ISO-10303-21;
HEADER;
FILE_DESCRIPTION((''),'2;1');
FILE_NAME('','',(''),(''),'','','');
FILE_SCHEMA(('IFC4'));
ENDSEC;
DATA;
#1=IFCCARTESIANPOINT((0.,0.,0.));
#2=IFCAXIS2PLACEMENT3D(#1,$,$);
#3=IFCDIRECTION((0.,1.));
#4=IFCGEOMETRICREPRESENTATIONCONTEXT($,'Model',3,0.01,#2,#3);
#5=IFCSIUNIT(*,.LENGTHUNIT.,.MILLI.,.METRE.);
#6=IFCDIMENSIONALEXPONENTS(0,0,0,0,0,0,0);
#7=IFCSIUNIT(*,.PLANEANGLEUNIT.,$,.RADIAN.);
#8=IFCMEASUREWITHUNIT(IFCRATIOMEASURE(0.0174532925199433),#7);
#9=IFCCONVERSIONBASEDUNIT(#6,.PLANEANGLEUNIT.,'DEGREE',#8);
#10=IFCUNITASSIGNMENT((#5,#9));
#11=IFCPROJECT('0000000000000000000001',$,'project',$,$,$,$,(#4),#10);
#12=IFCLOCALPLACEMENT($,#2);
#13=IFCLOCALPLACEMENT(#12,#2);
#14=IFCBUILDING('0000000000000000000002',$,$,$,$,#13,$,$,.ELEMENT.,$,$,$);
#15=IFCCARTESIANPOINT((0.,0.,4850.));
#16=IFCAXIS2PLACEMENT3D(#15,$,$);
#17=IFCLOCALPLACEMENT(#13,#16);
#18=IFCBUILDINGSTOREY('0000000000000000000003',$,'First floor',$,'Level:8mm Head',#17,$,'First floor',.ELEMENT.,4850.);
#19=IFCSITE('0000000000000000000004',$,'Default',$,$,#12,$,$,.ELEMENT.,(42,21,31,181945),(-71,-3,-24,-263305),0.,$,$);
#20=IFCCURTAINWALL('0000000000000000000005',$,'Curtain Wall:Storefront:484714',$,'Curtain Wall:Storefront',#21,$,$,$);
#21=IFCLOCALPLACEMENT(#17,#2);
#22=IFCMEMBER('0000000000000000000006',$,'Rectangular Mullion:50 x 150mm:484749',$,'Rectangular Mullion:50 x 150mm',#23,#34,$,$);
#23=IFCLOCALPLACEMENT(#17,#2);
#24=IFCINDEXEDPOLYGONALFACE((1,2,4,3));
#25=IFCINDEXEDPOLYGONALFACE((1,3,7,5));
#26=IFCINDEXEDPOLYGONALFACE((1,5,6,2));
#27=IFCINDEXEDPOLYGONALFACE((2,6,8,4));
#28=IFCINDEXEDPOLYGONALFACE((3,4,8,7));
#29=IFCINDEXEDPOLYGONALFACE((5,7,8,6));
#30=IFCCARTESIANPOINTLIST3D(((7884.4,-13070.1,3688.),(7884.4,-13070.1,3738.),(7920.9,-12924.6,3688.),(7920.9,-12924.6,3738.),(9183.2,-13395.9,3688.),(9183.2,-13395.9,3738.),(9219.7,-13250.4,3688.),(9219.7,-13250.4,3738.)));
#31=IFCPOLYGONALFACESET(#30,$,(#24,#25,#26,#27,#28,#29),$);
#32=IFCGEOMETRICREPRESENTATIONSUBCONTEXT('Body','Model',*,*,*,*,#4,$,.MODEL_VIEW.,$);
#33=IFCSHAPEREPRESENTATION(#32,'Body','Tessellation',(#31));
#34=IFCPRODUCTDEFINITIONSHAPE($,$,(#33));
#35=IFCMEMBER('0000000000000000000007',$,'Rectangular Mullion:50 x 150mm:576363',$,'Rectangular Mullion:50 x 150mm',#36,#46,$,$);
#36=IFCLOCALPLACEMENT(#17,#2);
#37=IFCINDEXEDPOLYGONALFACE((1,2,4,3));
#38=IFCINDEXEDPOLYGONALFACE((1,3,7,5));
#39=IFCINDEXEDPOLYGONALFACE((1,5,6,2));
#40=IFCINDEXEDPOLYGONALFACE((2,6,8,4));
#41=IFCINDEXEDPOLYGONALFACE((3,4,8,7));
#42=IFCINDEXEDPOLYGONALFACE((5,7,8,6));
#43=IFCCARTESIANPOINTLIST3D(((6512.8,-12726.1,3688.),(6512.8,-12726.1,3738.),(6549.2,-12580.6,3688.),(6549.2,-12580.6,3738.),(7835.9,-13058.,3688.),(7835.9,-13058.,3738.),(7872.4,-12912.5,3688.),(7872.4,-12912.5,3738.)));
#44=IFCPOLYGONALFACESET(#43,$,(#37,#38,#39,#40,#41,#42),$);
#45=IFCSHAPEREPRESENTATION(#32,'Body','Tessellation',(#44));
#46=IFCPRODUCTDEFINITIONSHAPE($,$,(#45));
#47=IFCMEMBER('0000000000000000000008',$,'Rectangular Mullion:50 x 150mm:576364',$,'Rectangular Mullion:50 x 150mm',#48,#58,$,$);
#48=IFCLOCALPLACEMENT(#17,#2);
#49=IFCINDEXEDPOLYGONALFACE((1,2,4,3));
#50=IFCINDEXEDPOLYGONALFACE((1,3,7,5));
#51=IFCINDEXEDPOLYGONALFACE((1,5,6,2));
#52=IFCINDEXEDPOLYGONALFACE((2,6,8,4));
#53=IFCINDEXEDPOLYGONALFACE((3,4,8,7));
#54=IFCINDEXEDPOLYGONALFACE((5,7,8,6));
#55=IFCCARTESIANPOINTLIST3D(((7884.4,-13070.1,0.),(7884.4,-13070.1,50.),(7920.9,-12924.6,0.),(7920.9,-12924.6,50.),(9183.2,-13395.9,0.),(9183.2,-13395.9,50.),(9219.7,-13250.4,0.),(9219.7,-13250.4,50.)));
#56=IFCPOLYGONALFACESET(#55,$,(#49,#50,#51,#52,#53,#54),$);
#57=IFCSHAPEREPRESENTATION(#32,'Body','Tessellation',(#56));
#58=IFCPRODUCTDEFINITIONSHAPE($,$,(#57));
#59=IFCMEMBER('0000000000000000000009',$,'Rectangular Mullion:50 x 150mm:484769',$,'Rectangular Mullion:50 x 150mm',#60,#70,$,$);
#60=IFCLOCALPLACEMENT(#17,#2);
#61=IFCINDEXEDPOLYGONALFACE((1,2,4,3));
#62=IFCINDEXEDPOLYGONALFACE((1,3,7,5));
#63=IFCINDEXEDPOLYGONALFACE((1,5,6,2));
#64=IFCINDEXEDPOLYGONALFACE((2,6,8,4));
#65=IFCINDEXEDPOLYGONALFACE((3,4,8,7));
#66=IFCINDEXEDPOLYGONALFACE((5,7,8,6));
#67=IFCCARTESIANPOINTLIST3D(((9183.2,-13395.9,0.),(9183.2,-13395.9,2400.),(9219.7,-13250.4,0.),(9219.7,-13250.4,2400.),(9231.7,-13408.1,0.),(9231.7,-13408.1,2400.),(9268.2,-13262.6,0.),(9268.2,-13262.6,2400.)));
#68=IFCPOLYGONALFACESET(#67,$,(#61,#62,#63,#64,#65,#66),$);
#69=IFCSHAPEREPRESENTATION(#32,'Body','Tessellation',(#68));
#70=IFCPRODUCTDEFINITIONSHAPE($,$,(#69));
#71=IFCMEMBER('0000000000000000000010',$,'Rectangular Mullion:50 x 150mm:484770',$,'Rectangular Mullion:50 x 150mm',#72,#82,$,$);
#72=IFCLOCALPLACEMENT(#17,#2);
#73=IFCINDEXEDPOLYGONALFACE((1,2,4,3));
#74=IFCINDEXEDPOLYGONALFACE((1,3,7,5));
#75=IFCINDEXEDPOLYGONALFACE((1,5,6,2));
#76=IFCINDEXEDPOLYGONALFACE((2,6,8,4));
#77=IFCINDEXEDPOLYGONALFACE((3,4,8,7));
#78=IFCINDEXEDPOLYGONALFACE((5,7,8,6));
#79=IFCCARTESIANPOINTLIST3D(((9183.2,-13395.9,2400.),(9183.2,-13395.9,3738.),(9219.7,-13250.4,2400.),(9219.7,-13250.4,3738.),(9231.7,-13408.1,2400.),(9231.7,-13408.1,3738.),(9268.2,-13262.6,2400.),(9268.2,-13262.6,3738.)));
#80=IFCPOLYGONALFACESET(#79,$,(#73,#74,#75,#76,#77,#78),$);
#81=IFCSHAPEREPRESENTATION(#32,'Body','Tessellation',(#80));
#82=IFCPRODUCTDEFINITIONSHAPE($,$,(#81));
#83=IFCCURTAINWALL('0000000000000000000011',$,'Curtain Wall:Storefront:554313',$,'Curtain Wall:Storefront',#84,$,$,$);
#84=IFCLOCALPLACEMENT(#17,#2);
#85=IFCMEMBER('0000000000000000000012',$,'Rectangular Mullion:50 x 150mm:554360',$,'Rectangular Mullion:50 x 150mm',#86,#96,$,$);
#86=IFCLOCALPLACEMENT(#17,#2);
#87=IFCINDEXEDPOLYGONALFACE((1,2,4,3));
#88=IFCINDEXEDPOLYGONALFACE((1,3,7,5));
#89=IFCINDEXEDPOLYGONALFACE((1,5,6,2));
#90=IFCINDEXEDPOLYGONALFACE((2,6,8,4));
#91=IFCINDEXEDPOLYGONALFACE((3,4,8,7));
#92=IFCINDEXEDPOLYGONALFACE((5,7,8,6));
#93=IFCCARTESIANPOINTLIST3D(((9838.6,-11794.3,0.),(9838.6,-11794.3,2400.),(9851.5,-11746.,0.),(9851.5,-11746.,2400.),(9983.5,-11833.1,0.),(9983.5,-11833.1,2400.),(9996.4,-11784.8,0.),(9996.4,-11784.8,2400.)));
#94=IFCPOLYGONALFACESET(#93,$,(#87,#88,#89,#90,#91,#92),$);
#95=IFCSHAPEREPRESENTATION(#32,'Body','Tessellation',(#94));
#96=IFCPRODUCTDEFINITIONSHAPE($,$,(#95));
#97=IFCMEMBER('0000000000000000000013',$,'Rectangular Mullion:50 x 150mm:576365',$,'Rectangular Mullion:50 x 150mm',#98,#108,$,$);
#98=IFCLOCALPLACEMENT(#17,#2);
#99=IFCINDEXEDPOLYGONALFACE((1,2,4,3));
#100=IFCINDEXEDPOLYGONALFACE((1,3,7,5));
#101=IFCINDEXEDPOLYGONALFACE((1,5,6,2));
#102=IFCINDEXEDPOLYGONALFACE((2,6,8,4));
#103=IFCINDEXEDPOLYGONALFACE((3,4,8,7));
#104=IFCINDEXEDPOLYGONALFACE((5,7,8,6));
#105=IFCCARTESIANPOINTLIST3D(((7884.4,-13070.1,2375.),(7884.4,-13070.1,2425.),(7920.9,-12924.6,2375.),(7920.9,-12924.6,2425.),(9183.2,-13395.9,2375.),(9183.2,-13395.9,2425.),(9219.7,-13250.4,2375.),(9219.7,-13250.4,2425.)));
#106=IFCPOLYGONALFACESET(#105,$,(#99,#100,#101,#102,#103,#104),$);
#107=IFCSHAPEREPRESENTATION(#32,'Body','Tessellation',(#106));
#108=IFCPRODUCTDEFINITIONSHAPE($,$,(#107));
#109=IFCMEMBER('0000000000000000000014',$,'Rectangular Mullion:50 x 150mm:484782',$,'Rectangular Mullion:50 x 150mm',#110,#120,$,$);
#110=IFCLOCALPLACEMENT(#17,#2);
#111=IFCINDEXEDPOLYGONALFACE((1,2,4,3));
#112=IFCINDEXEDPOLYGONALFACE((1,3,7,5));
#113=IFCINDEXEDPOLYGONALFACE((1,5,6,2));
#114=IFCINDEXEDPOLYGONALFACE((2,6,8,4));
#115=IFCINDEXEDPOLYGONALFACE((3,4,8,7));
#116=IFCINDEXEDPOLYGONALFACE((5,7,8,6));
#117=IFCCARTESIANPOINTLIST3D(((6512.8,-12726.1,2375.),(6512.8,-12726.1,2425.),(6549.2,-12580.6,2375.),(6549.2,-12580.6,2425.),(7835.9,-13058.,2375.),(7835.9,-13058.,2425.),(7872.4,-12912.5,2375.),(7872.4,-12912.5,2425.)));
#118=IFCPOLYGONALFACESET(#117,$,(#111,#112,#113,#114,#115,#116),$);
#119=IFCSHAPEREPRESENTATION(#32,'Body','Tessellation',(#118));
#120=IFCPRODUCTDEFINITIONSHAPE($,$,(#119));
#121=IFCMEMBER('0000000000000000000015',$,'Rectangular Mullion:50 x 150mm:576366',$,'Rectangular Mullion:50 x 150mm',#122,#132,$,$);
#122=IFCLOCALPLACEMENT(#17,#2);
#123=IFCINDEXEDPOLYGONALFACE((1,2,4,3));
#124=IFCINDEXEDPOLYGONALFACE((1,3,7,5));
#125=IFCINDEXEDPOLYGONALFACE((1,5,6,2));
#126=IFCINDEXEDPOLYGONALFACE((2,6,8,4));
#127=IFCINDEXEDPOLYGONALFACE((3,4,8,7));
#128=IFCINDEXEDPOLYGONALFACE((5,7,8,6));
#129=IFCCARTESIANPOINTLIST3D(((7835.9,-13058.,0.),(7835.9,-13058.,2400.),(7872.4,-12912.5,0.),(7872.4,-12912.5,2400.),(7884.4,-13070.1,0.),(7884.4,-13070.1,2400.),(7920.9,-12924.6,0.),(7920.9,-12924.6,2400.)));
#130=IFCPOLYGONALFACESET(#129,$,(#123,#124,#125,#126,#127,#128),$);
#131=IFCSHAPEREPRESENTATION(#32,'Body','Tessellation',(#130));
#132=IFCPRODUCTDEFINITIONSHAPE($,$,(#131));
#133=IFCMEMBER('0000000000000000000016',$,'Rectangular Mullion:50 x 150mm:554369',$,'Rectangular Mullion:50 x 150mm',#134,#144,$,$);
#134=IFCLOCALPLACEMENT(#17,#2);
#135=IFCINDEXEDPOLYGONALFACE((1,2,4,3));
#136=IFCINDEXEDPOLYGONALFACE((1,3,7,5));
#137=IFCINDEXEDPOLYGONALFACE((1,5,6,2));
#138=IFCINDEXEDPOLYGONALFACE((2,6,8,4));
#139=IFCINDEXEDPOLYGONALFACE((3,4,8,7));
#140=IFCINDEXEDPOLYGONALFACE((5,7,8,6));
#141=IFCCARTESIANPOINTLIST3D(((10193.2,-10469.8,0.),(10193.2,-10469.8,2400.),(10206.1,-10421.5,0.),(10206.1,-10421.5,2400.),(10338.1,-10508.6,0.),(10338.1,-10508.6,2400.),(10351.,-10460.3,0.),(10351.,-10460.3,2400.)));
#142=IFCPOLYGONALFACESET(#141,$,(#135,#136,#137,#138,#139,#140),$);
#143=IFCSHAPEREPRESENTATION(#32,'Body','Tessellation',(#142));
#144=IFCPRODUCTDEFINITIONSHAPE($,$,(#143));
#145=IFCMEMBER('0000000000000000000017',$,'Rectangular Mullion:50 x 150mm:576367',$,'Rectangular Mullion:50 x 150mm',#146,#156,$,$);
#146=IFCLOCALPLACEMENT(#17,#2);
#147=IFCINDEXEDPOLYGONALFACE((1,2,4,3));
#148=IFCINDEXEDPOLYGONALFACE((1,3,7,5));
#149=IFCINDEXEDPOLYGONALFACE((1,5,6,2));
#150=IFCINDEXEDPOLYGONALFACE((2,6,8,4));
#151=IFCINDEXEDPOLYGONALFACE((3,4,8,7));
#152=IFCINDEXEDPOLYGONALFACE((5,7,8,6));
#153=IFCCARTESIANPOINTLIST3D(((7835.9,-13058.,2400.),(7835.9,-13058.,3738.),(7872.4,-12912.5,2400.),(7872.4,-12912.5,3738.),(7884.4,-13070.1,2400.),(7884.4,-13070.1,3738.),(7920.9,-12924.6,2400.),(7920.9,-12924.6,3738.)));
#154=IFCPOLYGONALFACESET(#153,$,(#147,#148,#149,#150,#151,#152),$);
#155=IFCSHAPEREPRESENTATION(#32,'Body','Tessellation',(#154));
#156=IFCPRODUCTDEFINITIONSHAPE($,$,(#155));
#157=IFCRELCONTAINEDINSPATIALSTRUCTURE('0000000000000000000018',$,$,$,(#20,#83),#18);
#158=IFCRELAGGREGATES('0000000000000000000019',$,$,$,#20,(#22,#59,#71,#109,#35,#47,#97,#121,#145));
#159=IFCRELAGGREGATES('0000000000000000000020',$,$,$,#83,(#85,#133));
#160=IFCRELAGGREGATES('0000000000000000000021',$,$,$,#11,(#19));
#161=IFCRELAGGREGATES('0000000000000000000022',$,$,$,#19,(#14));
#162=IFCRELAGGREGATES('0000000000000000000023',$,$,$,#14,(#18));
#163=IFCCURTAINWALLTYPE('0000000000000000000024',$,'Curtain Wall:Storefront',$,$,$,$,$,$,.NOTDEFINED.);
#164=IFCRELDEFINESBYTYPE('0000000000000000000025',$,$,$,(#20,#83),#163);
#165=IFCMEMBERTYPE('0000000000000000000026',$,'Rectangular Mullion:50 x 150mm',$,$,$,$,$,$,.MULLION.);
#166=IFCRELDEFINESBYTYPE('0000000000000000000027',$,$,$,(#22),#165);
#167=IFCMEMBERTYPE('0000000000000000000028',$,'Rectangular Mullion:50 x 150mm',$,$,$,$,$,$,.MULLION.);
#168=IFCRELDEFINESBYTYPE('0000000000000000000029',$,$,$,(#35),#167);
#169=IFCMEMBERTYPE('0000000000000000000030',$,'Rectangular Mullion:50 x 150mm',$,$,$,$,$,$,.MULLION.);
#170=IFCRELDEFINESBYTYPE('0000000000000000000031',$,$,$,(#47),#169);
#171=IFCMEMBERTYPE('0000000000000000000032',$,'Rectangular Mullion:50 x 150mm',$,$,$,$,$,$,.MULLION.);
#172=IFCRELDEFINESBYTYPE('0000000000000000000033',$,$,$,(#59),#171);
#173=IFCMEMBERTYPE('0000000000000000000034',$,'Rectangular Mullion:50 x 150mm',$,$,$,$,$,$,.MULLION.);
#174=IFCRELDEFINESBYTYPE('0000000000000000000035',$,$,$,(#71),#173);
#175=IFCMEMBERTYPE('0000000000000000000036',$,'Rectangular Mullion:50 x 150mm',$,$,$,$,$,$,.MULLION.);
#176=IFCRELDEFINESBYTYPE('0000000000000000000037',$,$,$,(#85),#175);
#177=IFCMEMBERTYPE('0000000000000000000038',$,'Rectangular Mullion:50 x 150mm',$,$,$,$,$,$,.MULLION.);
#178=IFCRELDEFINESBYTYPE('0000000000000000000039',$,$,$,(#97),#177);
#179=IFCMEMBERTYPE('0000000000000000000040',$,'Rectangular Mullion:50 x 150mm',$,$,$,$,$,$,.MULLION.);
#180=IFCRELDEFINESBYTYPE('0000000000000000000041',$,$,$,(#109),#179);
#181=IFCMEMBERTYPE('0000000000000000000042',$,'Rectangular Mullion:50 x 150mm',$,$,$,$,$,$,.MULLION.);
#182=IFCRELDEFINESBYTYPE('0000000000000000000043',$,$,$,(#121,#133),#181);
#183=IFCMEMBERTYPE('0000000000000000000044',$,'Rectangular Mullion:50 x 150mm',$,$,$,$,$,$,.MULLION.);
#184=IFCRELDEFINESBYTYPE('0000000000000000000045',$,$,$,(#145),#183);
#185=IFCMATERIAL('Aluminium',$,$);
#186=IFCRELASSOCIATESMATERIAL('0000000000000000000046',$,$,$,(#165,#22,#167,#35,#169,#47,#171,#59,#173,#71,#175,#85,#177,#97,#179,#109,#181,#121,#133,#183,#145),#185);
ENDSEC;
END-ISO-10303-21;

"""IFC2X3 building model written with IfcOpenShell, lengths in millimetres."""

from ifc_helpers import new_model, entity, si_unit, converted_unit, direction, frame, origin, origin_2d_with_axis, place, context, subcontext, project, spatial, rectangle, extrude, source, transform, mapped, material, type_object, type_shapes, element, aggregate, save


model = new_model("IFC2X3")

# Units and contexts
model_context = context("Model", 3, precision=0.01, world=origin(), true_north=direction((0.0, 1.0)))
body_context = subcontext(model_context, "Body", "Model", "MODEL_VIEW")
ifc_project = project(units=[si_unit("LENGTHUNIT", "METRE", prefix="MILLI"), converted_unit("PLANEANGLEUNIT", "DEGREE", entity("IfcRatioMeasure", 0.0174532925199433), si_unit("PLANEANGLEUNIT", "RADIAN"), dimensions=[0, 0, 0, 0, 0, 0, 0])], contexts=[model_context])

# Site, building, storey
site_placement = place(None, origin())
site = spatial("IfcSite", under=ifc_project, at=site_placement, Name="Default", CompositionType="ELEMENT", RefLatitude=(42, 21, 31, 181945), RefLongitude=(-71, -3, -24, -263305), RefElevation=0.0)
building_placement = place(site_placement, origin())
building = spatial("IfcBuilding", under=site, at=building_placement, CompositionType="ELEMENT")
storey_placement = place(building_placement, frame((0.0, 0.0, 4850.0)))
storey = spatial("IfcBuildingStorey", under=building, at=storey_placement, Name="First floor", ObjectType="Level:8mm Head", LongName="First floor", CompositionType="ELEMENT", Elevation=4850.0)

# Curtain wall, members
curtain_wall_type = type_object("IfcCurtainWallType", Name="Curtain Wall:Storefront", PredefinedType="NOTDEFINED")
curtain_wall_1_placement = place(storey_placement, frame((0.0, 0.0, -4850.0)))
curtain_wall_1 = element("IfcCurtainWall", 1, at=curtain_wall_1_placement, inside=storey, type_object=curtain_wall_type, Name="Curtain Wall:Storefront:484714", ObjectType="Curtain Wall:Storefront")
ifc_material_1 = material(Name="Aluminium")
member_type_1 = type_object("IfcMemberType", Name="Rectangular Mullion:50 x 150mm", PredefinedType="MULLION", material=ifc_material_1)
shared_shape_1 = source(origin(), body_context, "Body", "SweptSolid", [
    extrude(rectangle(XDim=150.0, YDim=50.0, at=origin_2d_with_axis()), frame((-25.0, 0.0, -1339.1), z_axis=(0.0, 0.0, 1.0), x_axis=(0.0, -1.0, 0.0)), (0.0, 0.0, 1.0), 1339.1),
])
type_shapes(member_type_1, [shared_shape_1])
member_1_placement = place(storey_placement, frame((9201.5, -13323.1, 3738.0), z_axis=(0.96996, -0.243265, 0.0), x_axis=(0.0, 0.0, 1.0)))
member_1 = element("IfcMember", 2, at=member_1_placement, type_object=member_type_1, material=ifc_material_1, Name="Rectangular Mullion:50 x 150mm:484749", ObjectType="Rectangular Mullion:50 x 150mm", context=body_context, shape_type="MappedRepresentation", body=[
    mapped(shared_shape_1, transform((0.0, 0.0, 0.0), scale=1.0)),
])
member_type_2 = type_object("IfcMemberType", Name="Rectangular Mullion:50 x 150mm", PredefinedType="MULLION", material=ifc_material_1)
shared_shape_2 = source(origin(), body_context, "Body", "SweptSolid", [
    extrude(rectangle(XDim=150.0, YDim=50.0, at=origin_2d_with_axis()), frame((-25.0, 0.0, -1364.1), z_axis=(0.0, 0.0, 1.0), x_axis=(0.0, -1.0, 0.0)), (0.0, 0.0, 1.0), 1364.1),
])
type_shapes(member_type_2, [shared_shape_2])
member_2_placement = place(storey_placement, frame((7854.1, -12985.2, 3738.0), z_axis=(0.96996, -0.243265, 0.0), x_axis=(0.0, 0.0, 1.0)))
member_2 = element("IfcMember", 3, at=member_2_placement, type_object=member_type_2, material=ifc_material_1, Name="Rectangular Mullion:50 x 150mm:576363", ObjectType="Rectangular Mullion:50 x 150mm", context=body_context, shape_type="MappedRepresentation", body=[
    mapped(shared_shape_2, transform((0.0, 0.0, 0.0), scale=1.0)),
])
member_type_3 = type_object("IfcMemberType", Name="Rectangular Mullion:50 x 150mm", PredefinedType="MULLION", material=ifc_material_1)
shared_shape_3 = source(origin(), body_context, "Body", "SweptSolid", [
    extrude(rectangle(XDim=150.0, YDim=50.0, at=origin_2d_with_axis()), frame((-25.0, 0.0, -1339.1), z_axis=(0.0, 0.0, 1.0), x_axis=(0.0, -1.0, 0.0)), (0.0, 0.0, 1.0), 1339.1),
])
type_shapes(member_type_3, [shared_shape_3])
member_3_placement = place(storey_placement, frame((7902.6, -12997.4, 0.0), z_axis=(-0.96996, 0.243265, 0.0), x_axis=(0.0, 0.0, -1.0)))
member_3 = element("IfcMember", 4, at=member_3_placement, type_object=member_type_3, material=ifc_material_1, Name="Rectangular Mullion:50 x 150mm:576364", ObjectType="Rectangular Mullion:50 x 150mm", context=body_context, shape_type="MappedRepresentation", body=[
    mapped(shared_shape_3, transform((0.0, 0.0, 0.0), scale=1.0)),
])
member_type_4 = type_object("IfcMemberType", Name="Rectangular Mullion:50 x 150mm", PredefinedType="MULLION", material=ifc_material_1)
shared_shape_4 = source(origin(), body_context, "Body", "SweptSolid", [
    extrude(rectangle(XDim=150.0, YDim=50.0, at=origin_2d_with_axis()), frame((-25.0, 0.0, -2400.0), z_axis=(0.0, 0.0, 1.0), x_axis=(0.0, -1.0, 0.0)), (0.0, 0.0, 1.0), 2400.0),
])
type_shapes(member_type_4, [shared_shape_4])
member_4_placement = place(storey_placement, frame((9250.0, -13335.3, 0.0), z_axis=(0.0, 0.0, -1.0), x_axis=(0.96996, -0.243265, 0.0)))
member_4 = element("IfcMember", 5, at=member_4_placement, type_object=member_type_4, material=ifc_material_1, Name="Rectangular Mullion:50 x 150mm:484769", ObjectType="Rectangular Mullion:50 x 150mm", context=body_context, shape_type="MappedRepresentation", body=[
    mapped(shared_shape_4, transform((0.0, 0.0, 0.0), scale=1.0)),
])
member_type_5 = type_object("IfcMemberType", Name="Rectangular Mullion:50 x 150mm", PredefinedType="MULLION", material=ifc_material_1)
shared_shape_5 = source(origin(), body_context, "Body", "SweptSolid", [
    extrude(rectangle(XDim=150.0, YDim=50.0, at=origin_2d_with_axis()), frame((-25.0, 0.0, -1338.0), z_axis=(0.0, 0.0, 1.0), x_axis=(0.0, -1.0, 0.0)), (0.0, 0.0, 1.0), 1338.0),
])
type_shapes(member_type_5, [shared_shape_5])
member_5_placement = place(storey_placement, frame((9250.0, -13335.3, 2400.0), z_axis=(0.0, 0.0, -1.0), x_axis=(0.96996, -0.243265, 0.0)))
member_5 = element("IfcMember", 6, at=member_5_placement, type_object=member_type_5, material=ifc_material_1, Name="Rectangular Mullion:50 x 150mm:484770", ObjectType="Rectangular Mullion:50 x 150mm", context=body_context, shape_type="MappedRepresentation", body=[
    mapped(shared_shape_5, transform((0.0, 0.0, 0.0), scale=1.0)),
])

# Curtain wall, member
curtain_wall_2_placement = place(storey_placement, frame((0.0, 0.0, -4850.0)))
curtain_wall_2 = element("IfcCurtainWall", 7, at=curtain_wall_2_placement, inside=storey, type_object=curtain_wall_type, Name="Curtain Wall:Storefront:554313", ObjectType="Curtain Wall:Storefront")
member_type_6 = type_object("IfcMemberType", Name="Rectangular Mullion:50 x 150mm", PredefinedType="MULLION", material=ifc_material_1)
shared_shape_6 = source(origin(), body_context, "Body", "SweptSolid", [
    extrude(rectangle(XDim=150.0, YDim=50.0, at=origin_2d_with_axis()), frame((-25.0, 0.0, -2400.0), z_axis=(0.0, 0.0, 1.0), x_axis=(0.0, -1.0, 0.0)), (0.0, 0.0, 1.0), 2400.0),
])
type_shapes(member_type_6, [shared_shape_6])
member_6_placement = place(storey_placement, frame((9911.0, -11813.7, 2400.0), z_axis=(0.0, 0.0, 1.0), x_axis=(-0.258607, -0.965983, 0.0)))
member_6 = element("IfcMember", 8, at=member_6_placement, type_object=member_type_6, material=ifc_material_1, Name="Rectangular Mullion:50 x 150mm:554360", ObjectType="Rectangular Mullion:50 x 150mm", context=body_context, shape_type="MappedRepresentation", body=[
    mapped(shared_shape_6, transform((0.0, 0.0, 0.0), scale=1.0)),
])

# Members
member_type_7 = type_object("IfcMemberType", Name="Rectangular Mullion:50 x 150mm", PredefinedType="MULLION", material=ifc_material_1)
shared_shape_7 = source(origin(), body_context, "Body", "SweptSolid", [
    extrude(rectangle(XDim=150.0, YDim=50.0, at=origin_2d_with_axis()), frame((0.0, 0.0, -1339.1), z_axis=(0.0, 0.0, 1.0), x_axis=(0.0, -1.0, 0.0)), (0.0, 0.0, 1.0), 1339.1),
])
type_shapes(member_type_7, [shared_shape_7])
member_7_placement = place(storey_placement, frame((9201.5, -13323.1, 2400.0), z_axis=(0.96996, -0.243265, 0.0), x_axis=(0.0, 0.0, 1.0)))
member_7 = element("IfcMember", 9, at=member_7_placement, type_object=member_type_7, material=ifc_material_1, Name="Rectangular Mullion:50 x 150mm:576365", ObjectType="Rectangular Mullion:50 x 150mm", context=body_context, shape_type="MappedRepresentation", body=[
    mapped(shared_shape_7, transform((0.0, 0.0, 0.0), scale=1.0)),
])
member_type_8 = type_object("IfcMemberType", Name="Rectangular Mullion:50 x 150mm", PredefinedType="MULLION", material=ifc_material_1)
shared_shape_8 = source(origin(), body_context, "Body", "SweptSolid", [
    extrude(rectangle(XDim=150.0, YDim=50.0, at=origin_2d_with_axis()), frame((0.0, 0.0, -1364.1), z_axis=(0.0, 0.0, 1.0), x_axis=(0.0, -1.0, 0.0)), (0.0, 0.0, 1.0), 1364.1),
])
type_shapes(member_type_8, [shared_shape_8])
member_8_placement = place(storey_placement, frame((7854.1, -12985.2, 2400.0), z_axis=(0.96996, -0.243265, 0.0), x_axis=(0.0, 0.0, 1.0)))
member_8 = element("IfcMember", 10, at=member_8_placement, type_object=member_type_8, material=ifc_material_1, Name="Rectangular Mullion:50 x 150mm:484782", ObjectType="Rectangular Mullion:50 x 150mm", context=body_context, shape_type="MappedRepresentation", body=[
    mapped(shared_shape_8, transform((0.0, 0.0, 0.0), scale=1.0)),
])
member_type_9 = type_object("IfcMemberType", Name="Rectangular Mullion:50 x 150mm", PredefinedType="MULLION", material=ifc_material_1)
shared_shape_9 = source(origin(), body_context, "Body", "SweptSolid", [
    extrude(rectangle(XDim=150.0, YDim=50.0, at=origin_2d_with_axis()), frame((0.0, 0.0, -2400.0), z_axis=(0.0, 0.0, 1.0), x_axis=(0.0, -1.0, 0.0)), (0.0, 0.0, 1.0), 2400.0),
])
type_shapes(member_type_9, [shared_shape_9])
member_9_placement = place(storey_placement, frame((7878.4, -12991.3, 0.0), z_axis=(0.0, 0.0, -1.0), x_axis=(0.96996, -0.243265, 0.0)))
member_9 = element("IfcMember", 11, at=member_9_placement, type_object=member_type_9, material=ifc_material_1, Name="Rectangular Mullion:50 x 150mm:576366", ObjectType="Rectangular Mullion:50 x 150mm", context=body_context, shape_type="MappedRepresentation", body=[
    mapped(shared_shape_9, transform((0.0, 0.0, 0.0), scale=1.0)),
])
member_10_placement = place(storey_placement, frame((10272.1, -10465.1, 0.0), z_axis=(0.0, 0.0, -1.0), x_axis=(0.258607, 0.965983, 0.0)))
member_10 = element("IfcMember", 12, at=member_10_placement, type_object=member_type_9, material=ifc_material_1, Name="Rectangular Mullion:50 x 150mm:554369", ObjectType="Rectangular Mullion:50 x 150mm", context=body_context, shape_type="MappedRepresentation", body=[
    mapped(shared_shape_9, transform((0.0, 0.0, 0.0), scale=1.0)),
])
member_type_10 = type_object("IfcMemberType", Name="Rectangular Mullion:50 x 150mm", PredefinedType="MULLION", material=ifc_material_1)
shared_shape_10 = source(origin(), body_context, "Body", "SweptSolid", [
    extrude(rectangle(XDim=150.0, YDim=50.0, at=origin_2d_with_axis()), frame((0.0, 0.0, -1338.0), z_axis=(0.0, 0.0, 1.0), x_axis=(0.0, -1.0, 0.0)), (0.0, 0.0, 1.0), 1338.0),
])
type_shapes(member_type_10, [shared_shape_10])
member_11_placement = place(storey_placement, frame((7878.4, -12991.3, 2400.0), z_axis=(0.0, 0.0, -1.0), x_axis=(0.96996, -0.243265, 0.0)))
member_11 = element("IfcMember", 13, at=member_11_placement, type_object=member_type_10, material=ifc_material_1, Name="Rectangular Mullion:50 x 150mm:576367", ObjectType="Rectangular Mullion:50 x 150mm", context=body_context, shape_type="MappedRepresentation", body=[
    mapped(shared_shape_10, transform((0.0, 0.0, 0.0), scale=1.0)),
])

aggregate(curtain_wall_1, [member_1, member_4, member_5, member_8, member_2, member_3, member_7, member_9, member_11])
aggregate(curtain_wall_2, [member_6, member_10])

save(model, "model.ifc")
